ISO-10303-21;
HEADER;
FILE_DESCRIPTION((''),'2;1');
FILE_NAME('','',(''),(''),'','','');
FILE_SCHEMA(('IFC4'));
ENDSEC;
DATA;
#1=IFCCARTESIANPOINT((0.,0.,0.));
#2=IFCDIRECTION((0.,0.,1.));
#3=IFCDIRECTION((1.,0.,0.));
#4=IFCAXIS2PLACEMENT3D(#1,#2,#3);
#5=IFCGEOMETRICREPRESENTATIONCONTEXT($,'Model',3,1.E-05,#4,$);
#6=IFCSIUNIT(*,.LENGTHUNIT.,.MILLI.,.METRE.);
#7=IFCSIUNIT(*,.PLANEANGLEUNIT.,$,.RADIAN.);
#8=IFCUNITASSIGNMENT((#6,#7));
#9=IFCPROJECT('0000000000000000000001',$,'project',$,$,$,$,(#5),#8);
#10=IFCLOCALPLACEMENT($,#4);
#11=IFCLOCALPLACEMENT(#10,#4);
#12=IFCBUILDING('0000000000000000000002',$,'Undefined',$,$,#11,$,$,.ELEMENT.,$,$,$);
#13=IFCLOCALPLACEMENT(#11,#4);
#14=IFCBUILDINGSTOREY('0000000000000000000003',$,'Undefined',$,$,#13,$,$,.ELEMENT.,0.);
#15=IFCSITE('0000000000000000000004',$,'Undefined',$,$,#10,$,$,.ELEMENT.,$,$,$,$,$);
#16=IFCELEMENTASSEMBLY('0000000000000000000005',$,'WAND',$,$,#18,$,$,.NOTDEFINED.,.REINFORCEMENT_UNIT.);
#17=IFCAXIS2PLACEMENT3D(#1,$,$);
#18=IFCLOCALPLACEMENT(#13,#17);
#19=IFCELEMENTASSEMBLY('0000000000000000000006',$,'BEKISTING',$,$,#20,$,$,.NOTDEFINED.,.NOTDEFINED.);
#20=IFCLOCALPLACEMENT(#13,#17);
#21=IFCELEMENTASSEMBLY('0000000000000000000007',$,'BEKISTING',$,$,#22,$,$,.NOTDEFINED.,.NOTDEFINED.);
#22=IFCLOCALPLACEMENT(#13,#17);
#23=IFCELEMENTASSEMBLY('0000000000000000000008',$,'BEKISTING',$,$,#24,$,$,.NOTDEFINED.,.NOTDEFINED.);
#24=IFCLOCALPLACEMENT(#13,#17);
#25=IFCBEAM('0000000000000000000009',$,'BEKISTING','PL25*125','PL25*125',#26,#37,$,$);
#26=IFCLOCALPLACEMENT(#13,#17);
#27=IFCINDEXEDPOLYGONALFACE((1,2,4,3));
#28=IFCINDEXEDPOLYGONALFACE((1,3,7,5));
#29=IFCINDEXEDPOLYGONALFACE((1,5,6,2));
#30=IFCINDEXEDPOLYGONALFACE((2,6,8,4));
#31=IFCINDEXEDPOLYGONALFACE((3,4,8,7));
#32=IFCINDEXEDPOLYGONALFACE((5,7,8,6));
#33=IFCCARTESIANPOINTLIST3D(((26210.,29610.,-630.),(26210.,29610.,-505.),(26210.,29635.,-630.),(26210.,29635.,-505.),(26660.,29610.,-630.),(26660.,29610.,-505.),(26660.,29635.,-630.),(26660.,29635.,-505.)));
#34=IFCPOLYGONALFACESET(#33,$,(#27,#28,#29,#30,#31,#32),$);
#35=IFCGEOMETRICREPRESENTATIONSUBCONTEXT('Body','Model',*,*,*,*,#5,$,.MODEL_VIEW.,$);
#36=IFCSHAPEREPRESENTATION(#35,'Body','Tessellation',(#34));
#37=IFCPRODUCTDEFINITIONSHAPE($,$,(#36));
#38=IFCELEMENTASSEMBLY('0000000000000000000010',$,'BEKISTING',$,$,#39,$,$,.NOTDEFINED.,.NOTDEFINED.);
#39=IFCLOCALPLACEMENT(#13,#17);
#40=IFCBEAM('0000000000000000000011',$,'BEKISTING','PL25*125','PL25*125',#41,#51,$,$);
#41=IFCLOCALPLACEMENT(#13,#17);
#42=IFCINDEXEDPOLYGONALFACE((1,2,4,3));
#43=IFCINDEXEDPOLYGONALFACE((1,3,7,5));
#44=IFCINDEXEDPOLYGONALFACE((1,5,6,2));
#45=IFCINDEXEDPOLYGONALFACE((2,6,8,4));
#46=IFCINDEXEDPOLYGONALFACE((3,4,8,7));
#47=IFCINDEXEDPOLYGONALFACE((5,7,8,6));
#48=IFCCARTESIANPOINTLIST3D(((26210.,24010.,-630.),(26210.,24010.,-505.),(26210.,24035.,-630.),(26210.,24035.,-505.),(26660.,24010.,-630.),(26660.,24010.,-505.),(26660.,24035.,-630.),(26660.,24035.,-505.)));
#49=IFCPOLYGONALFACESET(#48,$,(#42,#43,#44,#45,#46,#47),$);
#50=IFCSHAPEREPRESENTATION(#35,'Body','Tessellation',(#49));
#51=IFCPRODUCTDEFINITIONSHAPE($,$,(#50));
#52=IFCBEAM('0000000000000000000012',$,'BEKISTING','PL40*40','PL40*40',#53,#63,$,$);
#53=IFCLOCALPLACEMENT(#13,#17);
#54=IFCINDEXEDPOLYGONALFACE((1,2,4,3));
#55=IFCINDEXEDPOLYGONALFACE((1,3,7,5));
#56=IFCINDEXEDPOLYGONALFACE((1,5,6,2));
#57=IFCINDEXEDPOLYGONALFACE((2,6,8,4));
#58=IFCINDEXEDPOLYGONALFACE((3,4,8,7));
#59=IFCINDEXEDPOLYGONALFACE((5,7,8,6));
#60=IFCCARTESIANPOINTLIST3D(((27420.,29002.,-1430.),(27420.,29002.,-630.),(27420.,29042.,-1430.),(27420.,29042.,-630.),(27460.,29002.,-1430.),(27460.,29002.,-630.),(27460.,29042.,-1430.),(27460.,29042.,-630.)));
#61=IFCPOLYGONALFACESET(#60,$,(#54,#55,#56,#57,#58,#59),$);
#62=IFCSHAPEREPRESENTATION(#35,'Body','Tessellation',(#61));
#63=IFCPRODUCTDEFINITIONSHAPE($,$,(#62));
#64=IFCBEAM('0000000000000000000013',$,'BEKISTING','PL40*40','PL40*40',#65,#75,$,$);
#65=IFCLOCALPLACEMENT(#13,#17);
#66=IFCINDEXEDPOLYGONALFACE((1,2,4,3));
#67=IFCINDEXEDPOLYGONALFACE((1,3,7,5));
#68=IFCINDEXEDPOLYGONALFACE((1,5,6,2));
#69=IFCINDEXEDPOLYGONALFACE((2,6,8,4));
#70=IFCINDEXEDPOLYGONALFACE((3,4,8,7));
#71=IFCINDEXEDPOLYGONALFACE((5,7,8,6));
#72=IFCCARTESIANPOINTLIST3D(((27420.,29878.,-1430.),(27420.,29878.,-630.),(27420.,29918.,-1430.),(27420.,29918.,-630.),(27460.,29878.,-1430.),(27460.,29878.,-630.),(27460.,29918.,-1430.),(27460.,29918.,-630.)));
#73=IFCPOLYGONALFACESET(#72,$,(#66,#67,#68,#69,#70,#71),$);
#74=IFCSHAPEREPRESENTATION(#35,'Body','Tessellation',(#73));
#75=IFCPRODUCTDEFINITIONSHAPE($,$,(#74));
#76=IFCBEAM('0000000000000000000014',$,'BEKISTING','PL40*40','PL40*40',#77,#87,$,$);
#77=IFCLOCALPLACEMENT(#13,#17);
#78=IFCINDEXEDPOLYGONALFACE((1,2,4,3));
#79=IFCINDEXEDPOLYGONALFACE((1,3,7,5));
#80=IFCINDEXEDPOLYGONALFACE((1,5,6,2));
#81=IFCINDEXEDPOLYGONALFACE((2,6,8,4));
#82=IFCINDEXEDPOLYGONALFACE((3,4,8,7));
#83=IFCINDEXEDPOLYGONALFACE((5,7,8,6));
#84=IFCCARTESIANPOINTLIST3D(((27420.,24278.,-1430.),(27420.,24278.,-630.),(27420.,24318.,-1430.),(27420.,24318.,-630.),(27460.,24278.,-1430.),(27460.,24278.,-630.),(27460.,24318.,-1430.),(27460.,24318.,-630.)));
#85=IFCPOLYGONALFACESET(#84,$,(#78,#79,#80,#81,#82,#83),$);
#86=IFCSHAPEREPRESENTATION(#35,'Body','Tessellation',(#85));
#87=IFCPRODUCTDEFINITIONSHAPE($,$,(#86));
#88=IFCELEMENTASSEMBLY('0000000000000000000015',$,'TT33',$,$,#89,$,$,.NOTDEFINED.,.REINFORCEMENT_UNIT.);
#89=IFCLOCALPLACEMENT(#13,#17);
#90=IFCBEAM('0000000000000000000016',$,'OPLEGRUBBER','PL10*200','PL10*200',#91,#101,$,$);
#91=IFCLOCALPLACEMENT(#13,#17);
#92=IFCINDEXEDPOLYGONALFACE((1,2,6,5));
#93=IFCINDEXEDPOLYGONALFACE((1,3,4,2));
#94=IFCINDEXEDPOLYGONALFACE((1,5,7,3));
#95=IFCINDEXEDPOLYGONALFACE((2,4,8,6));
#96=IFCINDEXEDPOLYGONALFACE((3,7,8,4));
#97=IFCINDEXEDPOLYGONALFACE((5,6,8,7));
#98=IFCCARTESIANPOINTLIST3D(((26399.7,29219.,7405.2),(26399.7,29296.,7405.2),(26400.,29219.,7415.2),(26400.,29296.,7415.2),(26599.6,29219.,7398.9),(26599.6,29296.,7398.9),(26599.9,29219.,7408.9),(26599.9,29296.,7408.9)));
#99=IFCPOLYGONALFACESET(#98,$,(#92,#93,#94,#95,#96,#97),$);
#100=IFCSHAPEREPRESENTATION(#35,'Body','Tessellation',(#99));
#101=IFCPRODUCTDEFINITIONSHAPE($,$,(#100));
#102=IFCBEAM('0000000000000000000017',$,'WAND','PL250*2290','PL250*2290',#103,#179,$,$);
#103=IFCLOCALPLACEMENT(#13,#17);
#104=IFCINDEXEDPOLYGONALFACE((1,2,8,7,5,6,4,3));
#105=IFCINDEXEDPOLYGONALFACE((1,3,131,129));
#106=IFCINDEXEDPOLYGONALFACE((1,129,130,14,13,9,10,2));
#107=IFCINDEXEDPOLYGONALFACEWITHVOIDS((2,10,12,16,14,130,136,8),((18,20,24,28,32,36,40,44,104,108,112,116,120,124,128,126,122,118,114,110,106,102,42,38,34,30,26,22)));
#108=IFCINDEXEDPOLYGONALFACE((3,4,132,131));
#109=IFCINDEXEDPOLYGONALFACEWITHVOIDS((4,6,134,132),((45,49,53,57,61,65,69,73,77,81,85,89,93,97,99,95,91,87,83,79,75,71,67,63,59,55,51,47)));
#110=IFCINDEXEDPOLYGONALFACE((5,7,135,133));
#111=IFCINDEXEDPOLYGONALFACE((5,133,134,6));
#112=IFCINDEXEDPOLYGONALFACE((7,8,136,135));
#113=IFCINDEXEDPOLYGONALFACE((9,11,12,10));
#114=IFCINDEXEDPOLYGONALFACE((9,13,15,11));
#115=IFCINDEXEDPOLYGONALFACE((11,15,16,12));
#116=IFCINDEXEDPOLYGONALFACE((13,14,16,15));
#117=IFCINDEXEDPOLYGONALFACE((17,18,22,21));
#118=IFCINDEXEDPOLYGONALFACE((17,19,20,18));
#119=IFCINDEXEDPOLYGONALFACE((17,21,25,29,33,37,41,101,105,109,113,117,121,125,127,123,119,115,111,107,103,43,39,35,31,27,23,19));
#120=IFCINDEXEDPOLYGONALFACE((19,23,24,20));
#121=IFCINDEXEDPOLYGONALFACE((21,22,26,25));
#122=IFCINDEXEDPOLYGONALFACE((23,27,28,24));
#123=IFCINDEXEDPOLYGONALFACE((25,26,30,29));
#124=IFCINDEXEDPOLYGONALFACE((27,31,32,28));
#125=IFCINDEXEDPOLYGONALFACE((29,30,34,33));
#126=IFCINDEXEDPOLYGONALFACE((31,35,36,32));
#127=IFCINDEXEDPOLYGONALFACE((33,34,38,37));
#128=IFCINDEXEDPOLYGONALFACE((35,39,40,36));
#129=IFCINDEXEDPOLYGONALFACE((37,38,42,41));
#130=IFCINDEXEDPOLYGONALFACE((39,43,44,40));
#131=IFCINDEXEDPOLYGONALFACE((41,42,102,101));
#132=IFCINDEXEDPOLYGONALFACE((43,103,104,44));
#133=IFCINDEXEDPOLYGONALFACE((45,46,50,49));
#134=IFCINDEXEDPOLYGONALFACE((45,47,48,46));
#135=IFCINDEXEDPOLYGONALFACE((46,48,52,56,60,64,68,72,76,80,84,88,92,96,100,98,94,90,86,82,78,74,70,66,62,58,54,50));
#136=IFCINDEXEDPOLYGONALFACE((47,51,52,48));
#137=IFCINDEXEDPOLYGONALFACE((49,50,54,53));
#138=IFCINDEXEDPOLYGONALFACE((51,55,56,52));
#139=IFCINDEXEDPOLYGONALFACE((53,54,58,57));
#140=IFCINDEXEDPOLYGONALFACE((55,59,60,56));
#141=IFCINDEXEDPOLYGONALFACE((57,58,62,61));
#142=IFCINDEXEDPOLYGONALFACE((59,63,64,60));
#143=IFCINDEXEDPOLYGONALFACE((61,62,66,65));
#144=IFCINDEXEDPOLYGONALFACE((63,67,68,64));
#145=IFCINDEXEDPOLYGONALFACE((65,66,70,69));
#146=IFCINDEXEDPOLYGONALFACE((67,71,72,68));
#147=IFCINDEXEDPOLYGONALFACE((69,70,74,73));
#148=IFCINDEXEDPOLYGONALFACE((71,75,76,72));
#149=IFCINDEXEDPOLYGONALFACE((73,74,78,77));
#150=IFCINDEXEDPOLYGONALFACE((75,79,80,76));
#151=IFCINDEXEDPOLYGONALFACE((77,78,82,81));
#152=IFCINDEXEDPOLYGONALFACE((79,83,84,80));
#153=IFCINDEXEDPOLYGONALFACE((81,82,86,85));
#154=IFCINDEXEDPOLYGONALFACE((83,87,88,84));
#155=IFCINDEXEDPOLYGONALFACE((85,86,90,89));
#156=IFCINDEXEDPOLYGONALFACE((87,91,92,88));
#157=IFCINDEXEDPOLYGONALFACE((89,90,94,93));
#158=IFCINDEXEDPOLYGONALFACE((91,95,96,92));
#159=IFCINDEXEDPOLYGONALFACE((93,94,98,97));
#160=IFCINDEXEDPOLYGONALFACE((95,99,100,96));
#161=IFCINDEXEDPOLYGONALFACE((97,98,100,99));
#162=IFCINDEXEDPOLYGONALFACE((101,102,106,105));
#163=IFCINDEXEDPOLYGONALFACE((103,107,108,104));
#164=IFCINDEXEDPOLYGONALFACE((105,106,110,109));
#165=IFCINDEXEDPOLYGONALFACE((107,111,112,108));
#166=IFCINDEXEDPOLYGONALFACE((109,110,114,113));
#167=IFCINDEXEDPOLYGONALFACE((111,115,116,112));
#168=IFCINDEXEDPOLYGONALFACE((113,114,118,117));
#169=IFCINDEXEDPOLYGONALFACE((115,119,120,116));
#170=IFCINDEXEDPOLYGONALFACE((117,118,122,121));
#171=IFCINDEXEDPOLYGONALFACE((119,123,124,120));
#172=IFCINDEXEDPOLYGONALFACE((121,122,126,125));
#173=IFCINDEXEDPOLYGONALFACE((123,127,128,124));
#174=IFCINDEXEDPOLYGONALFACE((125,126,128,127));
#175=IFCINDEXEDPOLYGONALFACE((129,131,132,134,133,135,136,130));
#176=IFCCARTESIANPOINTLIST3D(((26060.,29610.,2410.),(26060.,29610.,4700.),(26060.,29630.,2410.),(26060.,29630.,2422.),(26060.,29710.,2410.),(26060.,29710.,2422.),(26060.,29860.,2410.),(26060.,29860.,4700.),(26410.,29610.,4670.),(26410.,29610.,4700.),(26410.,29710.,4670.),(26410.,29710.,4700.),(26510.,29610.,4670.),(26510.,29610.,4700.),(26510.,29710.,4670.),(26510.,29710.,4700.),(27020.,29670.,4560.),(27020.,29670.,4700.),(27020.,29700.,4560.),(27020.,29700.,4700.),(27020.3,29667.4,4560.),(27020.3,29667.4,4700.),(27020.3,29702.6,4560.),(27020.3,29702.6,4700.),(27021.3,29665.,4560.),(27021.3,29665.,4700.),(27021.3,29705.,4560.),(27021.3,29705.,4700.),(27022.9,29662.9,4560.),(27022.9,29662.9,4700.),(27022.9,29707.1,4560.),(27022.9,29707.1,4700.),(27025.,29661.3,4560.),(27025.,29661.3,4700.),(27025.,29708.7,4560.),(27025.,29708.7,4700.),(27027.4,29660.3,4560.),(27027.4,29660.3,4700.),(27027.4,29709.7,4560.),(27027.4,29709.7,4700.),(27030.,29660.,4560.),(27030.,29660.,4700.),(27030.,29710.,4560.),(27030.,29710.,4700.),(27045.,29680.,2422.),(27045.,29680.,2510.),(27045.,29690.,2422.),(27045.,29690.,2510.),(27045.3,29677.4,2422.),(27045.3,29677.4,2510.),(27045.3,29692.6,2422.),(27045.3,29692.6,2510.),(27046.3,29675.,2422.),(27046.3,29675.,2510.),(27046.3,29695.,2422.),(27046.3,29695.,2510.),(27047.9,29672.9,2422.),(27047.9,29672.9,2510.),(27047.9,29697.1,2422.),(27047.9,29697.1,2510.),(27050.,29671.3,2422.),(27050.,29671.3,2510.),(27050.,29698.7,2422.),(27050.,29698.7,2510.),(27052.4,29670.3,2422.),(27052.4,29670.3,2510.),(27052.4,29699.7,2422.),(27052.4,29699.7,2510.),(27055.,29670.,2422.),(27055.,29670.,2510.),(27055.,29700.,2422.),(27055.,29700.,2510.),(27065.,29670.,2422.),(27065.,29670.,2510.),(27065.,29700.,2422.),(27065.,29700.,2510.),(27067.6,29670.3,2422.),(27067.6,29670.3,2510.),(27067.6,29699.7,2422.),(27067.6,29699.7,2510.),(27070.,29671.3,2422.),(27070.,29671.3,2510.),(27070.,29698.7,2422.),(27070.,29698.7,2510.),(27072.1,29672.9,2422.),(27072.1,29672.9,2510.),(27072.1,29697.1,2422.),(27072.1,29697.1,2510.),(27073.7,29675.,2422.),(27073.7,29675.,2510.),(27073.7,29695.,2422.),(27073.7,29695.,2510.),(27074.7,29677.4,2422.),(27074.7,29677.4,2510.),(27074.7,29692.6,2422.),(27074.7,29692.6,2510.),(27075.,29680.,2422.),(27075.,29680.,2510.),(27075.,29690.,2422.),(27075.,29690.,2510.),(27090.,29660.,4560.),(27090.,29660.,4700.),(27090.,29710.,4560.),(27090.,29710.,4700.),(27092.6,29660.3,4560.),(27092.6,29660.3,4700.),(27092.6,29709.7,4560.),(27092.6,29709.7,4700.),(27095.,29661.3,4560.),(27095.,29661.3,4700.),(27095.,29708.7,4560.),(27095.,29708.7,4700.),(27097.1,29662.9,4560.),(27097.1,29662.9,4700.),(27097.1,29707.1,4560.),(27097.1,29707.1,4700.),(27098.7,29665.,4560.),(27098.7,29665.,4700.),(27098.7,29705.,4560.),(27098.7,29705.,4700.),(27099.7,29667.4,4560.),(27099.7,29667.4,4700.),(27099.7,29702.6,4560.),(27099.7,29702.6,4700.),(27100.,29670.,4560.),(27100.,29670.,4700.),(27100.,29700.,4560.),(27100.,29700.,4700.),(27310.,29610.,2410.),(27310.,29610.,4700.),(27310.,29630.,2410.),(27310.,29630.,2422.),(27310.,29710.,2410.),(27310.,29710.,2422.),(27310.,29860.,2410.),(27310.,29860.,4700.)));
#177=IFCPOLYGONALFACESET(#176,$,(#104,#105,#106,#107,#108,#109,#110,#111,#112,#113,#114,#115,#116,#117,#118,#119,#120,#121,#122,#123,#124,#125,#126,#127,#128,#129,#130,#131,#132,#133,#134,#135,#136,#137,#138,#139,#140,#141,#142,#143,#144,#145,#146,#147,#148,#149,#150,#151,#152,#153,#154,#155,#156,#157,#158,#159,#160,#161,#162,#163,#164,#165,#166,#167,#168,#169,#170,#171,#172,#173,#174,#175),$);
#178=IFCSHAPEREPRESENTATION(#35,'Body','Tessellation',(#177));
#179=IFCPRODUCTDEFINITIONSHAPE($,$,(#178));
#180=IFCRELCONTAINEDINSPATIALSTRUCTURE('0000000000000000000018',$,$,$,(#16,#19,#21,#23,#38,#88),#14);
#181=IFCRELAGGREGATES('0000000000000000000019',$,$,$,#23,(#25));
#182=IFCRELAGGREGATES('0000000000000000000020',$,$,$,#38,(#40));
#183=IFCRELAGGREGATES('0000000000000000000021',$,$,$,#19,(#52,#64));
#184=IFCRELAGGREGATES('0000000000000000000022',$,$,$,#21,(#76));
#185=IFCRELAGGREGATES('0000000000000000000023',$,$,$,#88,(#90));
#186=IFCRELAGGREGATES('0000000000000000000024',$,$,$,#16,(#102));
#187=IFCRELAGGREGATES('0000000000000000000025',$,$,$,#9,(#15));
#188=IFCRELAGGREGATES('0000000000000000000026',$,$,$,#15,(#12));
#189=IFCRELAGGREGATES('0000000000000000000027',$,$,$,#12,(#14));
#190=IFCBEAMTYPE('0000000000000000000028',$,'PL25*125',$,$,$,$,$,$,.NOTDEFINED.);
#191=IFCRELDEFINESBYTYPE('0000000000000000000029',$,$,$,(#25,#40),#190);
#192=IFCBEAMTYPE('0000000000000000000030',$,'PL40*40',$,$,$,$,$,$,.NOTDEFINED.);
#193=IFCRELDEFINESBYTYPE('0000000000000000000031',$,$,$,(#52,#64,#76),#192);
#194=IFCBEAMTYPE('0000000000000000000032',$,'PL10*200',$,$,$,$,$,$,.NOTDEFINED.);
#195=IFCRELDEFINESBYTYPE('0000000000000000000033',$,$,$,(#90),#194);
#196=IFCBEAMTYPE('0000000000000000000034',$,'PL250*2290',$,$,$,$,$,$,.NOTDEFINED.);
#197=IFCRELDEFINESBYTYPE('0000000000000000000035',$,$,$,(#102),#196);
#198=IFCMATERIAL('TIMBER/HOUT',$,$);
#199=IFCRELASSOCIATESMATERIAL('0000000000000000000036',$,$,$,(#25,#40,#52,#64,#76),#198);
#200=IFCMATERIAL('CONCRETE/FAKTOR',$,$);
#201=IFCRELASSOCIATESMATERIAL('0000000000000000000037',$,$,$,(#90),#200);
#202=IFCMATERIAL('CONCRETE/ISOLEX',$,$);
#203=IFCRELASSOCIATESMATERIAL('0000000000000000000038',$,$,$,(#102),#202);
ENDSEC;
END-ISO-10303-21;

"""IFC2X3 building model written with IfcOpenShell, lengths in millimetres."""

from ifc_helpers import new_model, si_unit, frame, frame_2d, origin_with_axes, place, context, subcontext, project, spatial, polyline, circle_curve, parameter, trimmed, segment, composite_curve, rectangle, outline, extrude, boolean, material, type_object, element, aggregate, save


model = new_model("IFC2X3")

# Units and contexts
model_context = context("Model", 3, precision=1e-05, world=origin_with_axes())
body_context = subcontext(model_context, "Body", "Model", "MODEL_VIEW")
ifc_project = project(units=[si_unit("LENGTHUNIT", "METRE", prefix="MILLI"), si_unit("PLANEANGLEUNIT", "RADIAN")], contexts=[model_context])

# Site, building, storey
site_placement = place(None, origin_with_axes())
site = spatial("IfcSite", under=ifc_project, at=site_placement, Name="Undefined", CompositionType="ELEMENT")
building_placement = place(site_placement, origin_with_axes())
building = spatial("IfcBuilding", under=site, at=building_placement, Name="Undefined", CompositionType="ELEMENT")
storey_placement = place(building_placement, origin_with_axes())
storey = spatial("IfcBuildingStorey", under=building, at=storey_placement, Name="Undefined", CompositionType="ELEMENT", Elevation=0.0)

# Element assembly
assembly_1_placement = place(storey_placement, origin_with_axes())
assembly_1 = element("IfcElementAssembly", 1, at=assembly_1_placement, inside=storey, Name="WAND", AssemblyPlace="NOTDEFINED", PredefinedType="REINFORCEMENT_UNIT")
ifc_material_1 = material(Name="CONCRETE/FAKTOR")

# Shared definitions
ifc_material_2 = material(Name="CONCRETE/ISOLEX")

# Element assemblies
ifc_material_3 = material(Name="TIMBER/HOUT")
assembly_2_placement = place(storey_placement, origin_with_axes())
assembly_2 = element("IfcElementAssembly", 2, at=assembly_2_placement, inside=storey, Name="BEKISTING", AssemblyPlace="NOTDEFINED", PredefinedType="NOTDEFINED")
assembly_3_placement = place(storey_placement, origin_with_axes())
assembly_3 = element("IfcElementAssembly", 3, at=assembly_3_placement, inside=storey, Name="BEKISTING", AssemblyPlace="NOTDEFINED", PredefinedType="NOTDEFINED")

# Element assemblies, beams
beam_type_1 = type_object("IfcBeamType", Name="PL25*125", PredefinedType="NOTDEFINED")
assembly_4_placement = place(storey_placement, origin_with_axes())
assembly_4 = element("IfcElementAssembly", 4, at=assembly_4_placement, inside=storey, Name="BEKISTING", AssemblyPlace="NOTDEFINED", PredefinedType="NOTDEFINED")
beam_1_placement = place(assembly_4_placement, frame((26660.0, 29622.5, -567.5), z_axis=(0.0, 0.0, -1.0), x_axis=(-1.0, 0.0, 0.0)))
beam_1 = element("IfcBeam", 5, at=beam_1_placement, type_object=beam_type_1, material=ifc_material_3, Name="BEKISTING", Description="PL25*125", ObjectType="PL25*125", context=body_context, shape_type="SweptSolid", body=[
    extrude(rectangle(XDim=25.0, YDim=125.0, at=frame_2d((0.0, 0.0), x_axis=(1.0, 0.0))), frame((450.0, 0.0, 0.0), z_axis=(-1.0, 0.0, 0.0), x_axis=(0.0, -1.0, 0.0)), (0.0, 0.0, 1.0), 450.0),
])
aggregate(assembly_4, [beam_1])
assembly_5_placement = place(storey_placement, origin_with_axes())
assembly_5 = element("IfcElementAssembly", 6, at=assembly_5_placement, inside=storey, Name="BEKISTING", AssemblyPlace="NOTDEFINED", PredefinedType="NOTDEFINED")
beam_2_placement = place(assembly_5_placement, frame((26660.0, 24022.5, -567.5), z_axis=(0.0, 0.0, -1.0), x_axis=(-1.0, 0.0, 0.0)))
beam_2 = element("IfcBeam", 7, at=beam_2_placement, type_object=beam_type_1, material=ifc_material_3, Name="BEKISTING", Description="PL25*125", ObjectType="PL25*125", context=body_context, shape_type="SweptSolid", body=[
    extrude(rectangle(XDim=25.0, YDim=125.0, at=frame_2d((0.0, 0.0), x_axis=(1.0, 0.0))), frame((450.0, 0.0, 0.0), z_axis=(-1.0, 0.0, 0.0), x_axis=(0.0, -1.0, 0.0)), (0.0, 0.0, 1.0), 450.0),
])
aggregate(assembly_5, [beam_2])

# Beams
beam_type_2 = type_object("IfcBeamType", Name="PL40*40", PredefinedType="NOTDEFINED")
beam_3_placement = place(assembly_2_placement, frame((27440.0, 29022.0, -1430.0), z_axis=(0.0, 1.0, 0.0), x_axis=(0.0, 0.0, 1.0)))
beam_3 = element("IfcBeam", 8, at=beam_3_placement, type_object=beam_type_2, material=ifc_material_3, Name="BEKISTING", Description="PL40*40", ObjectType="PL40*40", context=body_context, shape_type="SweptSolid", body=[
    extrude(rectangle(XDim=40.0, YDim=40.0, at=frame_2d((0.0, 0.0), x_axis=(1.0, 0.0))), frame((800.0, 0.0, 0.0), z_axis=(-1.0, 0.0, 0.0), x_axis=(0.0, -1.0, 0.0)), (0.0, 0.0, 1.0), 800.0),
])
beam_4_placement = place(assembly_2_placement, frame((27440.0, 29898.0, -1430.0), z_axis=(0.0, 1.0, 0.0), x_axis=(0.0, 0.0, 1.0)))
beam_4 = element("IfcBeam", 9, at=beam_4_placement, type_object=beam_type_2, material=ifc_material_3, Name="BEKISTING", Description="PL40*40", ObjectType="PL40*40", context=body_context, shape_type="SweptSolid", body=[
    extrude(rectangle(XDim=40.0, YDim=40.0, at=frame_2d((0.0, 0.0), x_axis=(1.0, 0.0))), frame((800.0, 0.0, 0.0), z_axis=(-1.0, 0.0, 0.0), x_axis=(0.0, -1.0, 0.0)), (0.0, 0.0, 1.0), 800.0),
])
aggregate(assembly_2, [beam_3, beam_4])
beam_5_placement = place(assembly_3_placement, frame((27440.0, 24298.0, -1430.0), z_axis=(0.0, 1.0, 0.0), x_axis=(0.0, 0.0, 1.0)))
beam_5 = element("IfcBeam", 10, at=beam_5_placement, type_object=beam_type_2, material=ifc_material_3, Name="BEKISTING", Description="PL40*40", ObjectType="PL40*40", context=body_context, shape_type="SweptSolid", body=[
    extrude(rectangle(XDim=40.0, YDim=40.0, at=frame_2d((0.0, 0.0), x_axis=(1.0, 0.0))), frame((800.0, 0.0, 0.0), z_axis=(-1.0, 0.0, 0.0), x_axis=(0.0, -1.0, 0.0)), (0.0, 0.0, 1.0), 800.0),
])
aggregate(assembly_3, [beam_5])

# Element assembly, beam
assembly_6_placement = place(storey_placement, origin_with_axes())
assembly_6 = element("IfcElementAssembly", 11, at=assembly_6_placement, inside=storey, Name="TT33", AssemblyPlace="NOTDEFINED", PredefinedType="REINFORCEMENT_UNIT")
beam_type_3 = type_object("IfcBeamType", Name="PL10*200", PredefinedType="NOTDEFINED")
beam_6_placement = place(assembly_6_placement, frame((26499.8, 29296.0, 7407.0), z_axis=(-0.999516, 0.0, 0.031107), x_axis=(0.0, -1.0, 0.0)))
beam_6 = element("IfcBeam", 12, at=beam_6_placement, type_object=beam_type_3, material=ifc_material_1, Name="OPLEGRUBBER", Description="PL10*200", ObjectType="PL10*200", context=body_context, shape_type="SweptSolid", body=[
    extrude(rectangle(XDim=10.0, YDim=200.0, at=frame_2d((0.0, 0.0), x_axis=(1.0, 0.0))), frame((77.0, 0.0, 0.0), z_axis=(-1.0, 0.0, 0.0), x_axis=(0.0, -1.0, 0.0)), (0.0, 0.0, 1.0), 77.0),
])
aggregate(assembly_6, [beam_6])

# Beam
beam_type_4 = type_object("IfcBeamType", Name="PL250*2290", PredefinedType="NOTDEFINED")
beam_7_placement = place(assembly_1_placement, frame((27310.0, 29735.0, 3555.0), z_axis=(0.0, 0.0, 1.0), x_axis=(-1.0, 0.0, 0.0)))
beam_7 = element("IfcBeam", 13, at=beam_7_placement, type_object=beam_type_4, material=ifc_material_2, Name="WAND", Description="PL250*2290", ObjectType="PL250*2290", context=body_context, shape_type="CSG", body=[
    boolean("DIFFERENCE", boolean("DIFFERENCE", boolean("DIFFERENCE", boolean("DIFFERENCE", extrude(rectangle(XDim=250.0, YDim=2290.0, at=frame_2d((0.0, 0.0), x_axis=(1.0, 0.0))), frame((1250.0, 0.0, 0.0), z_axis=(-1.0, 0.0, 0.0), x_axis=(0.0, -1.0, 0.0)), (0.0, 0.0, 1.0), 1250.0), extrude(outline(composite_curve([segment(trimmed(circle_curve(frame_2d((10.0, 10.0), x_axis=(-1.0, 0.0)), 10.0), [parameter(0.0)], [parameter(1.570796)], True, "PARAMETER"), True, "CONTINUOUS"), segment(polyline([(10.0, 0.0), (40.0, 0.0)]), True, "CONTINUOUS"), segment(trimmed(circle_curve(frame_2d((40.0, 10.0), x_axis=(0.0, -1.0)), 10.0), [parameter(0.0)], [parameter(1.570796)], True, "PARAMETER"), True, "CONTINUOUS"), segment(polyline([(50.0, 10.0), (50.0, 70.0)]), True, "CONTINUOUS"), segment(trimmed(circle_curve(frame_2d((40.0, 70.0), x_axis=(1.0, 0.0)), 10.0), [parameter(0.0)], [parameter(1.570796)], True, "PARAMETER"), True, "CONTINUOUS"), segment(polyline([(40.0, 80.0), (10.0, 80.0)]), True, "CONTINUOUS"), segment(trimmed(circle_curve(frame_2d((10.0, 70.0), x_axis=(0.0, 1.0)), 10.0), [parameter(0.0)], [parameter(1.570796)], True, "PARAMETER"), True, "CONTINUOUS"), segment(polyline([(0.0, 70.0), (0.0, 10.0)]), True, "CONTINUOUS")], self_intersect=True)), frame((290.0, 25.0, 1005.0), z_axis=(0.0, 0.0, 1.0), x_axis=(0.0, 1.0, 0.0)), (0.0, 0.0, 1.0), 150.0)), extrude(rectangle(XDim=100.0, YDim=100.0, at=frame_2d((0.0, 0.0), x_axis=(1.0, 0.0))), frame((850.0, 75.0, 1115.0), z_axis=(0.0, 0.0, 1.0), x_axis=(-1.0, 0.0, 0.0)), (0.0, 0.0, 1.0), 30.0)), extrude(outline(composite_curve([segment(trimmed(circle_curve(frame_2d((10.0, 10.0), x_axis=(-1.0, 0.0)), 10.0), [parameter(0.0)], [parameter(1.570796)], True, "PARAMETER"), True, "CONTINUOUS"), segment(polyline([(10.0, 0.0), (20.0, 0.0)]), True, "CONTINUOUS"), segment(trimmed(circle_curve(frame_2d((20.0, 10.0), x_axis=(0.0, -1.0)), 10.0), [parameter(0.0)], [parameter(1.570796)], True, "PARAMETER"), True, "CONTINUOUS"), segment(polyline([(30.0, 10.0), (30.0, 20.0)]), True, "CONTINUOUS"), segment(trimmed(circle_curve(frame_2d((20.0, 20.0), x_axis=(1.0, 0.0)), 10.0), [parameter(0.0)], [parameter(1.570796)], True, "PARAMETER"), True, "CONTINUOUS"), segment(polyline([(20.0, 30.0), (10.0, 30.0)]), True, "CONTINUOUS"), segment(trimmed(circle_curve(frame_2d((10.0, 20.0), x_axis=(0.0, 1.0)), 10.0), [parameter(0.0)], [parameter(1.570796)], True, "PARAMETER"), True, "CONTINUOUS"), segment(polyline([(0.0, 20.0), (0.0, 10.0)]), True, "CONTINUOUS")], self_intersect=True)), frame((235.0, 65.0, -1145.0), z_axis=(0.0, 0.0, 1.0), x_axis=(0.0, -1.0, 0.0)), (0.0, 0.0, 1.0), 100.0)), extrude(rectangle(XDim=12.0, YDim=80.0, at=frame_2d((0.0, 0.0), x_axis=(1.0, 0.0))), frame((1250.0, 65.0, -1139.0), z_axis=(-1.0, 0.0, 0.0), x_axis=(0.0, 0.0, -1.0)), (0.0, 0.0, 1.0), 1250.0)),
])

aggregate(assembly_1, [beam_7])

save(model, "model.ifc")
